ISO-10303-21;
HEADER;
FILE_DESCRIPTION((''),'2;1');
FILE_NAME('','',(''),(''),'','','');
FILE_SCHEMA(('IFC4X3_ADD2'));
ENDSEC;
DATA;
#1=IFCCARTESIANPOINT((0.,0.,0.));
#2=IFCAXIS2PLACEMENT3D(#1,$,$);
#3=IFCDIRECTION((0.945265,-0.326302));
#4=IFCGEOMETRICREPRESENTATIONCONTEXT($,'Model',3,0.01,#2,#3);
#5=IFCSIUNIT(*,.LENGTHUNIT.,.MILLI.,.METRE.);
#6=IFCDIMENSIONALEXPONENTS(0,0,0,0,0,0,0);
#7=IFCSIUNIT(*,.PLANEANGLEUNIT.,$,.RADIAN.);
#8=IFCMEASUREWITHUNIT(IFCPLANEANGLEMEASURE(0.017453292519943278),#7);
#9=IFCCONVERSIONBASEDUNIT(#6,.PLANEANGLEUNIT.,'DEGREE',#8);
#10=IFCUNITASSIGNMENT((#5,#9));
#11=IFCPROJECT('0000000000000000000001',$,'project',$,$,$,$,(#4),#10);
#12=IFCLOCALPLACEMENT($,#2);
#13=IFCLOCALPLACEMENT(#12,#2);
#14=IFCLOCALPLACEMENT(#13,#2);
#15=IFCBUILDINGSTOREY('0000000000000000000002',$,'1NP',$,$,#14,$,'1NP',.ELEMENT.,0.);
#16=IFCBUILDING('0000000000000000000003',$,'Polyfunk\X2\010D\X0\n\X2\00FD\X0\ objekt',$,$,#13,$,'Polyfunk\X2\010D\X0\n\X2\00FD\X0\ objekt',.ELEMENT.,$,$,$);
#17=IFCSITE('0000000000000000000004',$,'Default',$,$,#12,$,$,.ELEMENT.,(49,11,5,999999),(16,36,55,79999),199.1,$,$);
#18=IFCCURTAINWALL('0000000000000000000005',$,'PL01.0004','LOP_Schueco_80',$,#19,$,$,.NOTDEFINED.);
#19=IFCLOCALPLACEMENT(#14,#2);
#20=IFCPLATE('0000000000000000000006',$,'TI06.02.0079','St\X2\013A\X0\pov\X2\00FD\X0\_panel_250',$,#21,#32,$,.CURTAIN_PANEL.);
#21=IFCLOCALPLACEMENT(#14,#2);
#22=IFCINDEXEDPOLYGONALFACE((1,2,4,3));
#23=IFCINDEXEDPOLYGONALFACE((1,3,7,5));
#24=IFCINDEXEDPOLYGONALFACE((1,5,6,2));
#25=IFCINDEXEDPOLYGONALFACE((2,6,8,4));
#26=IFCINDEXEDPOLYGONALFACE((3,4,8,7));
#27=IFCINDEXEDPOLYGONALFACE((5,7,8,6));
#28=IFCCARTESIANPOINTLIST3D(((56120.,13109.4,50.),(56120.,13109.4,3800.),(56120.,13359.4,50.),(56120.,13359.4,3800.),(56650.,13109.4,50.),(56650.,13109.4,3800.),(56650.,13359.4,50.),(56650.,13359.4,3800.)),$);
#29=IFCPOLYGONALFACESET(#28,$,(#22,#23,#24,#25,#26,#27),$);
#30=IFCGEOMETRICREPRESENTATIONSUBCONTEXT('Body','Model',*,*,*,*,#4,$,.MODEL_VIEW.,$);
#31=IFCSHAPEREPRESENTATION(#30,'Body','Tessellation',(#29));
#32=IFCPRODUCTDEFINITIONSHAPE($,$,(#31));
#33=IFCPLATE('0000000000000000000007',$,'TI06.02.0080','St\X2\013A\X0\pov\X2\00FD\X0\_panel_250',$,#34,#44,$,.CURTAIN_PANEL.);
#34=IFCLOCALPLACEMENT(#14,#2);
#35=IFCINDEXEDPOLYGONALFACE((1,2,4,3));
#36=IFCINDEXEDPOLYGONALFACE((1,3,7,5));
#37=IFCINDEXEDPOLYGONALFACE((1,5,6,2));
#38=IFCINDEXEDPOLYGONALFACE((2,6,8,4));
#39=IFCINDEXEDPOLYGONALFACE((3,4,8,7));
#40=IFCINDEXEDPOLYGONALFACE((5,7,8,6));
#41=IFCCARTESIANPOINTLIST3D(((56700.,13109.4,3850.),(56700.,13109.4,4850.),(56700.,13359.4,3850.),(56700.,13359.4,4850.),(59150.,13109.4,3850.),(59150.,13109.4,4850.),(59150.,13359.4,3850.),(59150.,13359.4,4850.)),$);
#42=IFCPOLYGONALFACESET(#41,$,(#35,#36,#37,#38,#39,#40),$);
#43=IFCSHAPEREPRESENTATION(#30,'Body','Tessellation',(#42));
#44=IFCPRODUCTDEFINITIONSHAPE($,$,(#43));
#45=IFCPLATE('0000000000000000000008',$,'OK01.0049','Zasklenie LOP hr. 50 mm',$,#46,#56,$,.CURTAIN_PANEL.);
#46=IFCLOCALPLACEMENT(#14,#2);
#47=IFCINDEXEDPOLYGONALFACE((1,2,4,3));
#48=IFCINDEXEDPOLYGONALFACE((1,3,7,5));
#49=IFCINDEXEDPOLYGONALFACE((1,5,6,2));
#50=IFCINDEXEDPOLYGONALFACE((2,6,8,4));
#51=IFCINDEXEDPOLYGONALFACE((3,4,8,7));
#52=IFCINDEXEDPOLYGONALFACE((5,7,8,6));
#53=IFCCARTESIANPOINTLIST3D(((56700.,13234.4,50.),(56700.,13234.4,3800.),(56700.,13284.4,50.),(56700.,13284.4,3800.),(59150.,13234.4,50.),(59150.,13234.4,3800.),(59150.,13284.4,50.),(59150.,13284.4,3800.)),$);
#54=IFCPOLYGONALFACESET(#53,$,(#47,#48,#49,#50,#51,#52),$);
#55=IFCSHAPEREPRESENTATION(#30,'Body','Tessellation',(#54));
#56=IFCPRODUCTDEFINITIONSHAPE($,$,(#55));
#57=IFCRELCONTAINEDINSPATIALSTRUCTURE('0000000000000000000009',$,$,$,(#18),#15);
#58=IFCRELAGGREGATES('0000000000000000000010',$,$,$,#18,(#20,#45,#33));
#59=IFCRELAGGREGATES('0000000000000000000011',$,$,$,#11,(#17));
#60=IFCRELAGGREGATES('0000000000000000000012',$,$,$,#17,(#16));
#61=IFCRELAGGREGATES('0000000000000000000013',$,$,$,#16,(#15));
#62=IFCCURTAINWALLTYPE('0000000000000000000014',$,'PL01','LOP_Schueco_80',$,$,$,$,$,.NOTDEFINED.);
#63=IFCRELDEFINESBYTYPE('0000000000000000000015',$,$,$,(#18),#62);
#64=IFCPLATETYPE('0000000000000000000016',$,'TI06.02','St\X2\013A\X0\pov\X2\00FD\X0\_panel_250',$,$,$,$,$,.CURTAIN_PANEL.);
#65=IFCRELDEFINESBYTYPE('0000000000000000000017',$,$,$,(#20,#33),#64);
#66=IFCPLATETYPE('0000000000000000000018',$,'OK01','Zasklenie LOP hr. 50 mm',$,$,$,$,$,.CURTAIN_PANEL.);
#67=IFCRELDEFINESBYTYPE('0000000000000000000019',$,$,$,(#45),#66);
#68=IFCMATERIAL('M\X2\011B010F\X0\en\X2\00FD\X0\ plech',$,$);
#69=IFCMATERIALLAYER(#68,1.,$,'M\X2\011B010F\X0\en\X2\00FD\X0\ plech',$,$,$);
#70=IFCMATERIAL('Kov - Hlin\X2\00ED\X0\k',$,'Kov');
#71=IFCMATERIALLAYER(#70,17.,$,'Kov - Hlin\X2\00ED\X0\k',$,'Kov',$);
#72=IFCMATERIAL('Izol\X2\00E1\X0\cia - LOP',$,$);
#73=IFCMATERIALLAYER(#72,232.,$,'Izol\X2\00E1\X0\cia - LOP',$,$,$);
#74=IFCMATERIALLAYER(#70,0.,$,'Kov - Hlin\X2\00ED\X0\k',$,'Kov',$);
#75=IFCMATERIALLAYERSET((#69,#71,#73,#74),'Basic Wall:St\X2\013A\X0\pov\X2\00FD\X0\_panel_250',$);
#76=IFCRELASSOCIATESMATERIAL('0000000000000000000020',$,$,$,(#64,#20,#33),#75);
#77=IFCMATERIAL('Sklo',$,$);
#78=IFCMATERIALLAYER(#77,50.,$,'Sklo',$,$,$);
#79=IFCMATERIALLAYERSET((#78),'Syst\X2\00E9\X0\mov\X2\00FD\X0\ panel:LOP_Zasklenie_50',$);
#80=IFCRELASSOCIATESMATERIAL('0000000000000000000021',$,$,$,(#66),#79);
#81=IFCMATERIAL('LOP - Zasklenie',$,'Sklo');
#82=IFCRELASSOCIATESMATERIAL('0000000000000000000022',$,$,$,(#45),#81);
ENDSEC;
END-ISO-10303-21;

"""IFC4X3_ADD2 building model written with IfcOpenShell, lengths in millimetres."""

from ifc_helpers import new_model, entity, si_unit, converted_unit, direction, frame, frame_2d, origin, place, context, subcontext, project, spatial, rectangle, extrude, source, transform, mapped, material, layer, layer_set, layer_usage, type_object, type_shapes, element, aggregate, save


model = new_model("IFC4X3_ADD2")

# Units and contexts
model_context = context("Model", 3, precision=0.01, world=origin(), true_north=direction((0.945265, -0.326302)))
body_context = subcontext(model_context, "Body", "Model", "MODEL_VIEW")
ifc_project = project(units=[si_unit("LENGTHUNIT", "METRE", prefix="MILLI"), converted_unit("PLANEANGLEUNIT", "DEGREE", entity("IfcPlaneAngleMeasure", 0.017453292519943278), si_unit("PLANEANGLEUNIT", "RADIAN"), dimensions=[0, 0, 0, 0, 0, 0, 0])], contexts=[model_context])

# Site, building, storey
site_placement = place(None, origin())
site = spatial("IfcSite", under=ifc_project, at=site_placement, Name="Default", CompositionType="ELEMENT", RefLatitude=(49, 11, 5, 999999), RefLongitude=(16, 36, 55, 79999), RefElevation=199.1)
building_placement = place(site_placement, origin())
building = spatial("IfcBuilding", under=site, at=building_placement, Name="Polyfunkčný objekt", LongName="Polyfunkčný objekt", CompositionType="ELEMENT")
storey_placement = place(building_placement, origin())
storey = spatial("IfcBuildingStorey", under=building, at=storey_placement, Name="1NP", LongName="1NP", CompositionType="ELEMENT", Elevation=0.0)

# Curtain wall, plates
curtain_wall_type = type_object("IfcCurtainWallType", Name="PL01", Description="LOP_Schueco_80", PredefinedType="NOTDEFINED")
curtain_wall_placement = place(storey_placement, origin())
curtain_wall = element("IfcCurtainWall", 1, at=curtain_wall_placement, inside=storey, type_object=curtain_wall_type, Name="PL01.0004", Description="LOP_Schueco_80", PredefinedType="NOTDEFINED")
ifc_material_1 = material(Name="Měďený plech")
ifc_layer_1 = layer(ifc_material_1, 1.0, Name="Měďený plech")
ifc_material_2 = material(Name="Kov - Hliník", Category="Kov")
ifc_layer_2 = layer(ifc_material_2, 17.0, Name="Kov - Hliník", Category="Kov")
ifc_material_3 = material(Name="Izolácia - LOP")
ifc_layer_3 = layer(ifc_material_3, 232.0, Name="Izolácia - LOP")
ifc_layer_4 = layer(ifc_material_2, 0.0, Name="Kov - Hliník", Category="Kov")
ifc_layer_set_1 = layer_set([ifc_layer_1, ifc_layer_2, ifc_layer_3, ifc_layer_4], Name="Basic Wall:Stĺpový_panel_250")
ifc_layer_usage_1 = layer_usage(ifc_layer_set_1, "AXIS2", "NEGATIVE", 125.0)
plate_type_1 = type_object("IfcPlateType", Name="TI06.02", Description="Stĺpový_panel_250", PredefinedType="CURTAIN_PANEL", material=ifc_layer_set_1)
plate_1_placement = place(storey_placement, frame((56120.0, 13234.4, 50.0)))
plate_1 = element("IfcPlate", 2, at=plate_1_placement, type_object=plate_type_1, material=ifc_layer_usage_1, Name="TI06.02.0079", Description="Stĺpový_panel_250", PredefinedType="CURTAIN_PANEL", context=body_context, shape_type="SweptSolid", body=[
    extrude(rectangle(XDim=250.0, YDim=530.0, at=frame_2d((0.0, 0.0), x_axis=(1.0, 0.0))), frame((265.0, 0.0, 0.0), z_axis=(0.0, 0.0, 1.0), x_axis=(0.0, 1.0, 0.0)), (0.0, 0.0, 1.0), 3750.0),
])
ifc_layer_usage_2 = layer_usage(ifc_layer_set_1, "AXIS2", "NEGATIVE", 125.0)
plate_2_placement = place(storey_placement, frame((56700.0, 13234.4, 3850.0)))
plate_2 = element("IfcPlate", 3, at=plate_2_placement, type_object=plate_type_1, material=ifc_layer_usage_2, Name="TI06.02.0080", Description="Stĺpový_panel_250", PredefinedType="CURTAIN_PANEL", context=body_context, shape_type="SweptSolid", body=[
    extrude(rectangle(XDim=250.0, YDim=2450.0, at=frame_2d((0.0, 0.0), x_axis=(1.0, 0.0))), frame((1225.0, 0.0, 0.0), z_axis=(0.0, 0.0, 1.0), x_axis=(0.0, 1.0, 0.0)), (0.0, 0.0, 1.0), 1000.0),
])
ifc_material_4 = material(Name="LOP - Zasklenie", Category="Sklo")
ifc_material_5 = material(Name="Sklo")
ifc_layer_5 = layer(ifc_material_5, 50.0, Name="Sklo")
ifc_layer_set_2 = layer_set([ifc_layer_5], Name="Systémový panel:LOP_Zasklenie_50")
plate_type_2 = type_object("IfcPlateType", Name="OK01", Description="Zasklenie LOP hr. 50 mm", PredefinedType="CURTAIN_PANEL", material=ifc_layer_set_2)
shared_shape_1 = source(origin(), body_context, "Body", "SweptSolid", [
    extrude(rectangle(XDim=3750.0, YDim=2450.0, at=frame_2d((-141.7, 0.0), x_axis=(1.0, 0.0))), frame((0.0, 0.0, 2016.7), z_axis=(0.0, 1.0, 0.0), x_axis=(0.0, 0.0, 1.0)), (0.0, 0.0, 1.0), 50.0),
])
type_shapes(plate_type_2, [shared_shape_1])
plate_3_placement = place(curtain_wall_placement, frame((57925.0, 13234.4, 50.0)))
plate_3 = element("IfcPlate", 4, at=plate_3_placement, type_object=plate_type_2, material=ifc_material_4, Name="OK01.0049", Description="Zasklenie LOP hr. 50 mm", PredefinedType="CURTAIN_PANEL", context=body_context, shape_type="MappedRepresentation", body=[
    mapped(shared_shape_1, transform((0.0, 0.0, 0.0), scale=1.0)),
])
aggregate(curtain_wall, [plate_1, plate_3, plate_2])

save(model, "model.ifc")
